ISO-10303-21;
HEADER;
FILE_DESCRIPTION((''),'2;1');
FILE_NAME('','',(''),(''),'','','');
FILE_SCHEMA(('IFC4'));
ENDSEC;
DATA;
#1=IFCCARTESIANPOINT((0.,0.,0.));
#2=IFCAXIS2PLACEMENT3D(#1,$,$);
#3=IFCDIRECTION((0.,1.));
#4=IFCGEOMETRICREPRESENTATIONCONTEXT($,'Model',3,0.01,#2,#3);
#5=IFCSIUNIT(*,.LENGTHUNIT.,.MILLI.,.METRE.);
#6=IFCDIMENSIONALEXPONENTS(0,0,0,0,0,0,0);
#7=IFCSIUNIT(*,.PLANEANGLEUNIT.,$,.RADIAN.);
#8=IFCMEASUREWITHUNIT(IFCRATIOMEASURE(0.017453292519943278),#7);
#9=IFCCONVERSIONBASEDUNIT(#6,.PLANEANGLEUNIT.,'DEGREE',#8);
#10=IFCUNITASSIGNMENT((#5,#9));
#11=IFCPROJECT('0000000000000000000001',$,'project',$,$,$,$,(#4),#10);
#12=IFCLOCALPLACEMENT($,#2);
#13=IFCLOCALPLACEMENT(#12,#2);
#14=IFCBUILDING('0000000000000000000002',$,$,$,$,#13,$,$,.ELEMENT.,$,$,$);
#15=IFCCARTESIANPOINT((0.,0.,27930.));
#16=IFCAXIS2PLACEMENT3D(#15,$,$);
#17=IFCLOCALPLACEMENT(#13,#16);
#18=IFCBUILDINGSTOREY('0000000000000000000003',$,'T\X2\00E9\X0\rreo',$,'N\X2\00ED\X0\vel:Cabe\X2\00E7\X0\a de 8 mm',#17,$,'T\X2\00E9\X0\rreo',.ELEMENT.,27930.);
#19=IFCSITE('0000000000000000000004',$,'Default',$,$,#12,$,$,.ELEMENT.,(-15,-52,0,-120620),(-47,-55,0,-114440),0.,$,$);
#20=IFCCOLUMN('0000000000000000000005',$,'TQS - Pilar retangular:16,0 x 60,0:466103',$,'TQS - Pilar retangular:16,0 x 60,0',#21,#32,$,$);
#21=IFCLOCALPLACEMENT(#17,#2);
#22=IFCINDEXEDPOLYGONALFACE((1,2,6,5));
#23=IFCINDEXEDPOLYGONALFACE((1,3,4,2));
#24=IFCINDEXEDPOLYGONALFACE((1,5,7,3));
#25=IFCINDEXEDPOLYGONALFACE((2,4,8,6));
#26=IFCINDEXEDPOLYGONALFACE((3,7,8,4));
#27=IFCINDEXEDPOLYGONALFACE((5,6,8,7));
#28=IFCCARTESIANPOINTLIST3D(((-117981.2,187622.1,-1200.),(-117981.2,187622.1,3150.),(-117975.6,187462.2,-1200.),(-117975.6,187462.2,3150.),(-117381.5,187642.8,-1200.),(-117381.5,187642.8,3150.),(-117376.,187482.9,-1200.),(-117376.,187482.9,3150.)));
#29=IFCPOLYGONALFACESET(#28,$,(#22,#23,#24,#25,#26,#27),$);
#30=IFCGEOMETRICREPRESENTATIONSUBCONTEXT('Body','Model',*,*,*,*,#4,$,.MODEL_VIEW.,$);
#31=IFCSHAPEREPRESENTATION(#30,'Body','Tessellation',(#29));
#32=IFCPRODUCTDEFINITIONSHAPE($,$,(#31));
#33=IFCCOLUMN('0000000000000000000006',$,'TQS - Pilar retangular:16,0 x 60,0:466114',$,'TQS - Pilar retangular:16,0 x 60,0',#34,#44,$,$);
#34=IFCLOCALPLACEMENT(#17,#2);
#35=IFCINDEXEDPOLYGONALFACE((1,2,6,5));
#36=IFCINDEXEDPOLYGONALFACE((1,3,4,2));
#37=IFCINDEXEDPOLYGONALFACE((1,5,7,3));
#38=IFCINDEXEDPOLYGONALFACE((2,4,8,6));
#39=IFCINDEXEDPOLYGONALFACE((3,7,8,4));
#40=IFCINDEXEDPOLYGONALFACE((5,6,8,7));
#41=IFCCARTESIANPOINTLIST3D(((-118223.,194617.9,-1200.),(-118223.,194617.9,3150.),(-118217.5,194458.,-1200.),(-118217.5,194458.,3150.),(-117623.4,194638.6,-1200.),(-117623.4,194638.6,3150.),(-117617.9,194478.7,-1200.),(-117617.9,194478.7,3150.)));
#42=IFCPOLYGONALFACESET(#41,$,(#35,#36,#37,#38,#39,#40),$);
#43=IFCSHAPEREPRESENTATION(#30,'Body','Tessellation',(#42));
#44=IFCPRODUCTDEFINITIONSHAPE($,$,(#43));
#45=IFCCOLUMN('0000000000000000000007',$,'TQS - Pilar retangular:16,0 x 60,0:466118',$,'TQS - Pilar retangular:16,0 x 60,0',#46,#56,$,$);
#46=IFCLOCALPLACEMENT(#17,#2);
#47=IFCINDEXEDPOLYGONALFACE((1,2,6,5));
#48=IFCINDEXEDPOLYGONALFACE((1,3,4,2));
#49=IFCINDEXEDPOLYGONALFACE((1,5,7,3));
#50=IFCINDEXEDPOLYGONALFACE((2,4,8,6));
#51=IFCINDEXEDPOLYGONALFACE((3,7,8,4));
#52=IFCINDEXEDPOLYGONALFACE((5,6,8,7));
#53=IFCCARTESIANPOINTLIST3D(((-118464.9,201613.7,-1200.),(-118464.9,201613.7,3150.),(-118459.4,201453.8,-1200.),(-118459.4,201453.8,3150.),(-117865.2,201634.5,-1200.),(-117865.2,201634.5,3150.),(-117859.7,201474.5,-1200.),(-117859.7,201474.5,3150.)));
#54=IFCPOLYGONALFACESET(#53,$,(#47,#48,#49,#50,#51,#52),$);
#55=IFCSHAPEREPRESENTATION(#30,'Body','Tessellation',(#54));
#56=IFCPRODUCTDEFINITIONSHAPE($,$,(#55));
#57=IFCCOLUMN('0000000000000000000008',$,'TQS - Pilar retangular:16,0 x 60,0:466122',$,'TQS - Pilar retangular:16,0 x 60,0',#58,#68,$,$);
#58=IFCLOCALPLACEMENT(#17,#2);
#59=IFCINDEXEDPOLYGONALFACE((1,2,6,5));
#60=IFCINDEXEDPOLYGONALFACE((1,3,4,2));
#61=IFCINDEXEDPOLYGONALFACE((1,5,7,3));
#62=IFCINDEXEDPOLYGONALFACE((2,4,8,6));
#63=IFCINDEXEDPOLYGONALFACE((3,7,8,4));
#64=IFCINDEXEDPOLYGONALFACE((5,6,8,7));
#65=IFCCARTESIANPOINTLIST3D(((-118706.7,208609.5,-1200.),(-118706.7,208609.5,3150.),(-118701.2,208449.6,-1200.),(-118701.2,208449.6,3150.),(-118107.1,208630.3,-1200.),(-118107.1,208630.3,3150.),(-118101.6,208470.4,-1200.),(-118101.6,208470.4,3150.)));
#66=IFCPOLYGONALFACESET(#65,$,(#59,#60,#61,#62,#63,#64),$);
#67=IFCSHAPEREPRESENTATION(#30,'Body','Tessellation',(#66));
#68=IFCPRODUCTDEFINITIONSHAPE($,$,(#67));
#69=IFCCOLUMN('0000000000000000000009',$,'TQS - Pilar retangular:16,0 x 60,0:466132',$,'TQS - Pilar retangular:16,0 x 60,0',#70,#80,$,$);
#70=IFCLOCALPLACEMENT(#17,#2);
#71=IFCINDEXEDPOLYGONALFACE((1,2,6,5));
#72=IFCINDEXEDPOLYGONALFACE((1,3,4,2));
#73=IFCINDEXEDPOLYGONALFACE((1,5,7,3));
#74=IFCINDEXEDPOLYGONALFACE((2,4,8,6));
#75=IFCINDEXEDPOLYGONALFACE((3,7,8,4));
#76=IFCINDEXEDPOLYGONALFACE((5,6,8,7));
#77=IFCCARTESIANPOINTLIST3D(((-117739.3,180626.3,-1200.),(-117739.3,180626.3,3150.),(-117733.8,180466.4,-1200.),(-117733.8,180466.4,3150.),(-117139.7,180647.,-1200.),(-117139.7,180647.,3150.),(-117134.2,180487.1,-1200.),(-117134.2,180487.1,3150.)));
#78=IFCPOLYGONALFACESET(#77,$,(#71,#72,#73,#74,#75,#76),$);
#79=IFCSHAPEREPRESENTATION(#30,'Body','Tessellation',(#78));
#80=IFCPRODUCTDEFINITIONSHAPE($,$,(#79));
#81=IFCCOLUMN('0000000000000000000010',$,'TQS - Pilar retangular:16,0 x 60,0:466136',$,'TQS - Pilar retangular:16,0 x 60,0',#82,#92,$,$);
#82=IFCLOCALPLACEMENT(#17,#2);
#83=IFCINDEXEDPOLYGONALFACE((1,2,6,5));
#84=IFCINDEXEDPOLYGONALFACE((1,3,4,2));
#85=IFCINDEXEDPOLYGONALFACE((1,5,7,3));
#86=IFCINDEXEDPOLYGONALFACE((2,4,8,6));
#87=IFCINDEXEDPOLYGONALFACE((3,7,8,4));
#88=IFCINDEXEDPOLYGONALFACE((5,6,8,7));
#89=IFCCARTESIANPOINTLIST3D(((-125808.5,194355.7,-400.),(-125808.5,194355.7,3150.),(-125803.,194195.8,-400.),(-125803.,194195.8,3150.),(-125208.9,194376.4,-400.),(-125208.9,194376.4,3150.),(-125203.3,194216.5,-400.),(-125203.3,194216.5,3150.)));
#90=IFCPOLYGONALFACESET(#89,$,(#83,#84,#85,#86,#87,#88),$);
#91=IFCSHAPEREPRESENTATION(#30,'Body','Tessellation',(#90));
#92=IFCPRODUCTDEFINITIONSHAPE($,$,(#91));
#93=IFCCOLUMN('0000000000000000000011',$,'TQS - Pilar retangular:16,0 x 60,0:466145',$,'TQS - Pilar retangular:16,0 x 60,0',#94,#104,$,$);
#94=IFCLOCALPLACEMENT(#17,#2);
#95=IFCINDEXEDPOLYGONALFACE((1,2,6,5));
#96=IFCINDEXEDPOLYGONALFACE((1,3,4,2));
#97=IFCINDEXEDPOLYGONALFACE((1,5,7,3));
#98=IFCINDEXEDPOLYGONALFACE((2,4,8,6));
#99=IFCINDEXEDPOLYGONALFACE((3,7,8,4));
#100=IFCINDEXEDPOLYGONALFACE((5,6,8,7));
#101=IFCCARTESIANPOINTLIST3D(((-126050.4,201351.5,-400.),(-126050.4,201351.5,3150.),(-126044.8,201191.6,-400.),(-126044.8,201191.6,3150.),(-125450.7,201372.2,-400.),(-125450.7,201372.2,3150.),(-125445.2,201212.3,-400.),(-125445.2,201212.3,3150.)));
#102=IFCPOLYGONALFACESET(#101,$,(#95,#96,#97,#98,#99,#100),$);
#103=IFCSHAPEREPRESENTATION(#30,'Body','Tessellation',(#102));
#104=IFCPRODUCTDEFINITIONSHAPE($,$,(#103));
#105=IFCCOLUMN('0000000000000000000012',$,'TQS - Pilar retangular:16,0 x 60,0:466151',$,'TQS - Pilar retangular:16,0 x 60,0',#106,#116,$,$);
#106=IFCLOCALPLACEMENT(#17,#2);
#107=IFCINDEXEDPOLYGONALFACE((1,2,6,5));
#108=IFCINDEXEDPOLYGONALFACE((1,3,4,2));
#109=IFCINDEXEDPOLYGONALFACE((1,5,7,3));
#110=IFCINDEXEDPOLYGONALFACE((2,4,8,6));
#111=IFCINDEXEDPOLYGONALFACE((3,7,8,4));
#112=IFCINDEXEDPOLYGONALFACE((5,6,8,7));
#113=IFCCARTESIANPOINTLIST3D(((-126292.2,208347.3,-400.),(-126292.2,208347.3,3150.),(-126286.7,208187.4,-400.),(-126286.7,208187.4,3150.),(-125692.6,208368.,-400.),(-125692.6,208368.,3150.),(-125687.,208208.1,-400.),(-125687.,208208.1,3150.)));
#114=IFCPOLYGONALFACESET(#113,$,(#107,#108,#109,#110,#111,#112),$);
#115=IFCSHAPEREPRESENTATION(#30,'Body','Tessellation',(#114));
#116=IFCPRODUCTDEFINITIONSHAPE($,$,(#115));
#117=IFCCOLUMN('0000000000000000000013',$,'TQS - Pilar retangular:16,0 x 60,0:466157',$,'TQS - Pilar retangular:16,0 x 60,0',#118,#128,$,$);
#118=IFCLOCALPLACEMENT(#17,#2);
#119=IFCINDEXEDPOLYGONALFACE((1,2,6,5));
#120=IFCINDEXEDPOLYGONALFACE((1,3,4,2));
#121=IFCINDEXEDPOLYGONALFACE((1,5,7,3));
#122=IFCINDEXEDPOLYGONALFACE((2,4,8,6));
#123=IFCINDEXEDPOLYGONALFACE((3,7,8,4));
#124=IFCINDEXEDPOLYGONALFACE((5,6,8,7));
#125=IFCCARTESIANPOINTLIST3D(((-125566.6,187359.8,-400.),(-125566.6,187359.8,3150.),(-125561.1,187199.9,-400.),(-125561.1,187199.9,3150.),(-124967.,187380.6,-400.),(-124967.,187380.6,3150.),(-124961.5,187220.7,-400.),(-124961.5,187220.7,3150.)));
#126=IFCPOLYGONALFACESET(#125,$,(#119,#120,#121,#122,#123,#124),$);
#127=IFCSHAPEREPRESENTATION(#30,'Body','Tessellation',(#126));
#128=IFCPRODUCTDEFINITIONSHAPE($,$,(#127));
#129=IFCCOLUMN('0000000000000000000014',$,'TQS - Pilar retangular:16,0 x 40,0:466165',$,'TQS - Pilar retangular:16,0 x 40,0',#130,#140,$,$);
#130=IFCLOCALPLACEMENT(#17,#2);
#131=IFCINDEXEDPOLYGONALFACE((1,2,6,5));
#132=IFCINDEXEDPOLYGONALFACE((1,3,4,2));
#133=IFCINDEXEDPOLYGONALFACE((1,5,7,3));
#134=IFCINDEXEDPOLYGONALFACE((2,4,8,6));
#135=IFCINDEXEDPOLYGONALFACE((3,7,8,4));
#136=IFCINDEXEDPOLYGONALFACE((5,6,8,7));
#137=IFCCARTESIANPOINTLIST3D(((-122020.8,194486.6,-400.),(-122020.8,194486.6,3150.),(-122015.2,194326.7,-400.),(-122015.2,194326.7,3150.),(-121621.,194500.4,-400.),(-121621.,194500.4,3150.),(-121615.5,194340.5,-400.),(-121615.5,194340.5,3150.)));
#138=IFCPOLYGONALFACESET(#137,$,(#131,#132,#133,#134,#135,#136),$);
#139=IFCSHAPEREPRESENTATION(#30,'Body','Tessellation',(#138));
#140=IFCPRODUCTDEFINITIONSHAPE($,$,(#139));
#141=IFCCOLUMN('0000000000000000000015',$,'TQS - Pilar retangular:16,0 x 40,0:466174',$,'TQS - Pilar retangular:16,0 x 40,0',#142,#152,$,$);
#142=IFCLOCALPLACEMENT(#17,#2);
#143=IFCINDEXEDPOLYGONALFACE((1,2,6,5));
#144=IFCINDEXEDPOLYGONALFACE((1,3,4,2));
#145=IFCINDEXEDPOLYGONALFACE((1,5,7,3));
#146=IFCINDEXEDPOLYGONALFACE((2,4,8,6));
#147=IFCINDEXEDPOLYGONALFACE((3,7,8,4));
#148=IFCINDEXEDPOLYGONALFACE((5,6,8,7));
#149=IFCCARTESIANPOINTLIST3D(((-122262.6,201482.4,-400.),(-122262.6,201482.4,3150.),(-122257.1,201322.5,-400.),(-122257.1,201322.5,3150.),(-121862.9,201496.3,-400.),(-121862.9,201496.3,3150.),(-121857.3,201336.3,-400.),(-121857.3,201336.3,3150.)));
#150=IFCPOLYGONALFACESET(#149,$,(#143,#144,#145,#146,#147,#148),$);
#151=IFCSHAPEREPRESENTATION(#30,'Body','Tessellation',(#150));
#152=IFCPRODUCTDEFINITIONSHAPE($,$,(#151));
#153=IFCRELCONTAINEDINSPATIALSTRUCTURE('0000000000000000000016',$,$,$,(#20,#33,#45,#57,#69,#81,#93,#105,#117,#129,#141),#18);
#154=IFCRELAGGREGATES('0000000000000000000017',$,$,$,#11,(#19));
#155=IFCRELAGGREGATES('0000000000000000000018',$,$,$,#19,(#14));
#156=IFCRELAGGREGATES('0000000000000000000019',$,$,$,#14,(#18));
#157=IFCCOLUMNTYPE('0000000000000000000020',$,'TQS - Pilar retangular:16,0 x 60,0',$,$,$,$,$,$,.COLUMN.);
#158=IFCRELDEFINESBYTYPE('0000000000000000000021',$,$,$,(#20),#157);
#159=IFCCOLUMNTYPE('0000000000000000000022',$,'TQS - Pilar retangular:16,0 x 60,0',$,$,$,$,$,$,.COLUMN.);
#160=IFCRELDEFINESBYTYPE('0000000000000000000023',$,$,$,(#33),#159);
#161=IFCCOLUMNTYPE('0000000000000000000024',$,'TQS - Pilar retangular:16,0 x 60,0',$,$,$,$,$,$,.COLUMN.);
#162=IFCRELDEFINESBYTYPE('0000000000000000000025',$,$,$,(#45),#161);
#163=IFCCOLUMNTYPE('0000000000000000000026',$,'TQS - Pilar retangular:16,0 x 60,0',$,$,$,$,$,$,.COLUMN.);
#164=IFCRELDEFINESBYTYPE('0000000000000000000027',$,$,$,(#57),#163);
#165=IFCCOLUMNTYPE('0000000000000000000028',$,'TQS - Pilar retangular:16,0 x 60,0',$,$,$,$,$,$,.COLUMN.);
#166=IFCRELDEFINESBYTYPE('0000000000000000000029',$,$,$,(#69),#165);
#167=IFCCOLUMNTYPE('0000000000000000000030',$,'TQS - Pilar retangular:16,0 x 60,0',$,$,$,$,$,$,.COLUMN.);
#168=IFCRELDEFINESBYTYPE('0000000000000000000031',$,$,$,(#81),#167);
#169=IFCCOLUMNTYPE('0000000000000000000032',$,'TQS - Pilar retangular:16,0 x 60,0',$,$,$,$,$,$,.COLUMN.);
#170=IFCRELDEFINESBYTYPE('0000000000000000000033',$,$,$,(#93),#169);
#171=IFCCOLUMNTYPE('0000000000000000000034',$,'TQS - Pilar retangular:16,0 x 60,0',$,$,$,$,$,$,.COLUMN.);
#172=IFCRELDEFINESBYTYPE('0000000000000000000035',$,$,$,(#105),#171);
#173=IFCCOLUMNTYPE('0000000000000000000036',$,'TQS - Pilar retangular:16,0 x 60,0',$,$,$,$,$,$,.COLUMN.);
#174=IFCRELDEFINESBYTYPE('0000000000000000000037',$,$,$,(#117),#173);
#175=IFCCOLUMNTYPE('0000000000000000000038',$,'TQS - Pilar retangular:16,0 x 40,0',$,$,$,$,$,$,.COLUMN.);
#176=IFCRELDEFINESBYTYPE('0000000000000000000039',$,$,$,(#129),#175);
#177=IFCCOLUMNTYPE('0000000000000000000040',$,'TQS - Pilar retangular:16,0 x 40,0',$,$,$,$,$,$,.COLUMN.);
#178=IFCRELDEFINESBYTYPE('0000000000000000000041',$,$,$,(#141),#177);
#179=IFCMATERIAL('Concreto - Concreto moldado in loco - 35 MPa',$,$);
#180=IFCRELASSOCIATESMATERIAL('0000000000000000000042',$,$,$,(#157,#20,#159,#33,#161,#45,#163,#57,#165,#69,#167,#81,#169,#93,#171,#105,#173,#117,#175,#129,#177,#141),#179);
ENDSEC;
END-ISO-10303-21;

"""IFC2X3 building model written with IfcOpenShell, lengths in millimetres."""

from ifc_helpers import new_model, entity, si_unit, converted_unit, direction, frame, origin, origin_2d_with_axis, place, context, subcontext, project, spatial, rectangle, extrude, source, transform, mapped, material, type_object, type_shapes, element, save


model = new_model("IFC2X3")

# Units and contexts
model_context = context("Model", 3, precision=0.01, world=origin(), true_north=direction((0.0, 1.0)))
body_context = subcontext(model_context, "Body", "Model", "MODEL_VIEW")
ifc_project = project(units=[si_unit("LENGTHUNIT", "METRE", prefix="MILLI"), converted_unit("PLANEANGLEUNIT", "DEGREE", entity("IfcRatioMeasure", 0.017453292519943278), si_unit("PLANEANGLEUNIT", "RADIAN"), dimensions=[0, 0, 0, 0, 0, 0, 0])], contexts=[model_context])

# Site, building, storey
site_placement = place(None, origin())
site = spatial("IfcSite", under=ifc_project, at=site_placement, Name="Default", CompositionType="ELEMENT", RefLatitude=(-15, -52, 0, -120620), RefLongitude=(-47, -55, 0, -114440), RefElevation=0.0)
building_placement = place(site_placement, origin())
building = spatial("IfcBuilding", under=site, at=building_placement, CompositionType="ELEMENT")
storey_placement = place(building_placement, frame((0.0, 0.0, 27930.0)))
storey = spatial("IfcBuildingStorey", under=building, at=storey_placement, Name="Térreo", ObjectType="Nível:Cabeça de 8 mm", LongName="Térreo", CompositionType="ELEMENT", Elevation=27930.0)

# Columns
ifc_material = material(Name="Concreto - Concreto moldado in loco - 35 MPa")
column_type_1 = type_object("IfcColumnType", Name="TQS - Pilar retangular:16,0 x 60,0", PredefinedType="COLUMN", material=ifc_material)
shared_shape_1 = source(origin(), body_context, "Body", "SweptSolid", [
    extrude(rectangle(XDim=600.0, YDim=160.0, at=origin_2d_with_axis()), frame((-117678.6, 187552.5, 26730.0), z_axis=(0.0, 0.0, 1.0), x_axis=(-0.999403, -0.034551, 0.0)), (0.0, 0.0, 1.0), 4350.0),
])
type_shapes(column_type_1, [shared_shape_1])
column_1_placement = place(storey_placement, frame((0.0, 0.0, -27930.0)))
element("IfcColumn", 1, at=column_1_placement, inside=storey, type_object=column_type_1, material=ifc_material, Name="TQS - Pilar retangular:16,0 x 60,0:466103", ObjectType="TQS - Pilar retangular:16,0 x 60,0", context=body_context, shape_type="MappedRepresentation", body=[
    mapped(shared_shape_1, transform((0.0, 0.0, 0.0), scale=1.0)),
])
column_type_2 = type_object("IfcColumnType", Name="TQS - Pilar retangular:16,0 x 60,0", PredefinedType="COLUMN", material=ifc_material)
shared_shape_2 = source(origin(), body_context, "Body", "SweptSolid", [
    extrude(rectangle(XDim=600.0, YDim=160.0, at=origin_2d_with_axis()), frame((-117920.4, 194548.3, 26730.0), z_axis=(0.0, 0.0, 1.0), x_axis=(-0.999403, -0.034551, 0.0)), (0.0, 0.0, 1.0), 4350.0),
])
type_shapes(column_type_2, [shared_shape_2])
column_2_placement = place(storey_placement, frame((0.0, 0.0, -27930.0)))
element("IfcColumn", 2, at=column_2_placement, inside=storey, type_object=column_type_2, material=ifc_material, Name="TQS - Pilar retangular:16,0 x 60,0:466114", ObjectType="TQS - Pilar retangular:16,0 x 60,0", context=body_context, shape_type="MappedRepresentation", body=[
    mapped(shared_shape_2, transform((0.0, 0.0, 0.0), scale=1.0)),
])
column_type_3 = type_object("IfcColumnType", Name="TQS - Pilar retangular:16,0 x 60,0", PredefinedType="COLUMN", material=ifc_material)
shared_shape_3 = source(origin(), body_context, "Body", "SweptSolid", [
    extrude(rectangle(XDim=600.0, YDim=160.0, at=origin_2d_with_axis()), frame((-118162.3, 201544.1, 26730.0), z_axis=(0.0, 0.0, 1.0), x_axis=(-0.999403, -0.034551, 0.0)), (0.0, 0.0, 1.0), 4350.0),
])
type_shapes(column_type_3, [shared_shape_3])
column_3_placement = place(storey_placement, frame((0.0, 0.0, -27930.0)))
element("IfcColumn", 3, at=column_3_placement, inside=storey, type_object=column_type_3, material=ifc_material, Name="TQS - Pilar retangular:16,0 x 60,0:466118", ObjectType="TQS - Pilar retangular:16,0 x 60,0", context=body_context, shape_type="MappedRepresentation", body=[
    mapped(shared_shape_3, transform((0.0, 0.0, 0.0), scale=1.0)),
])
column_type_4 = type_object("IfcColumnType", Name="TQS - Pilar retangular:16,0 x 60,0", PredefinedType="COLUMN", material=ifc_material)
shared_shape_4 = source(origin(), body_context, "Body", "SweptSolid", [
    extrude(rectangle(XDim=600.0, YDim=160.0, at=origin_2d_with_axis()), frame((-118404.2, 208540.0, 26730.0), z_axis=(0.0, 0.0, 1.0), x_axis=(-0.999403, -0.034551, 0.0)), (0.0, 0.0, 1.0), 4350.0),
])
type_shapes(column_type_4, [shared_shape_4])
column_4_placement = place(storey_placement, frame((0.0, 0.0, -27930.0)))
element("IfcColumn", 4, at=column_4_placement, inside=storey, type_object=column_type_4, material=ifc_material, Name="TQS - Pilar retangular:16,0 x 60,0:466122", ObjectType="TQS - Pilar retangular:16,0 x 60,0", context=body_context, shape_type="MappedRepresentation", body=[
    mapped(shared_shape_4, transform((0.0, 0.0, 0.0), scale=1.0)),
])
column_type_5 = type_object("IfcColumnType", Name="TQS - Pilar retangular:16,0 x 60,0", PredefinedType="COLUMN", material=ifc_material)
shared_shape_5 = source(origin(), body_context, "Body", "SweptSolid", [
    extrude(rectangle(XDim=600.0, YDim=160.0, at=origin_2d_with_axis()), frame((-117436.7, 180556.7, 26730.0), z_axis=(0.0, 0.0, 1.0), x_axis=(-0.999403, -0.034551, 0.0)), (0.0, 0.0, 1.0), 4350.0),
])
type_shapes(column_type_5, [shared_shape_5])
column_5_placement = place(storey_placement, frame((0.0, 0.0, -27930.0)))
element("IfcColumn", 5, at=column_5_placement, inside=storey, type_object=column_type_5, material=ifc_material, Name="TQS - Pilar retangular:16,0 x 60,0:466132", ObjectType="TQS - Pilar retangular:16,0 x 60,0", context=body_context, shape_type="MappedRepresentation", body=[
    mapped(shared_shape_5, transform((0.0, 0.0, 0.0), scale=1.0)),
])
column_type_6 = type_object("IfcColumnType", Name="TQS - Pilar retangular:16,0 x 60,0", PredefinedType="COLUMN", material=ifc_material)
shared_shape_6 = source(origin(), body_context, "Body", "SweptSolid", [
    extrude(rectangle(XDim=600.0, YDim=160.0, at=origin_2d_with_axis()), frame((-125505.9, 194286.1, 27530.0), z_axis=(0.0, 0.0, 1.0), x_axis=(-0.999403, -0.034551, 0.0)), (0.0, 0.0, 1.0), 3550.0),
])
type_shapes(column_type_6, [shared_shape_6])
column_6_placement = place(storey_placement, frame((0.0, 0.0, -27930.0)))
element("IfcColumn", 6, at=column_6_placement, inside=storey, type_object=column_type_6, material=ifc_material, Name="TQS - Pilar retangular:16,0 x 60,0:466136", ObjectType="TQS - Pilar retangular:16,0 x 60,0", context=body_context, shape_type="MappedRepresentation", body=[
    mapped(shared_shape_6, transform((0.0, 0.0, 0.0), scale=1.0)),
])
column_type_7 = type_object("IfcColumnType", Name="TQS - Pilar retangular:16,0 x 60,0", PredefinedType="COLUMN", material=ifc_material)
shared_shape_7 = source(origin(), body_context, "Body", "SweptSolid", [
    extrude(rectangle(XDim=600.0, YDim=160.0, at=origin_2d_with_axis()), frame((-125747.8, 201281.9, 27530.0), z_axis=(0.0, 0.0, 1.0), x_axis=(-0.999403, -0.034551, 0.0)), (0.0, 0.0, 1.0), 3550.0),
])
type_shapes(column_type_7, [shared_shape_7])
column_7_placement = place(storey_placement, frame((0.0, 0.0, -27930.0)))
element("IfcColumn", 7, at=column_7_placement, inside=storey, type_object=column_type_7, material=ifc_material, Name="TQS - Pilar retangular:16,0 x 60,0:466145", ObjectType="TQS - Pilar retangular:16,0 x 60,0", context=body_context, shape_type="MappedRepresentation", body=[
    mapped(shared_shape_7, transform((0.0, 0.0, 0.0), scale=1.0)),
])
column_type_8 = type_object("IfcColumnType", Name="TQS - Pilar retangular:16,0 x 60,0", PredefinedType="COLUMN", material=ifc_material)
shared_shape_8 = source(origin(), body_context, "Body", "SweptSolid", [
    extrude(rectangle(XDim=600.0, YDim=160.0, at=origin_2d_with_axis()), frame((-125989.6, 208277.7, 27530.0), z_axis=(0.0, 0.0, 1.0), x_axis=(-0.999403, -0.034551, 0.0)), (0.0, 0.0, 1.0), 3550.0),
])
type_shapes(column_type_8, [shared_shape_8])
column_8_placement = place(storey_placement, frame((0.0, 0.0, -27930.0)))
element("IfcColumn", 8, at=column_8_placement, inside=storey, type_object=column_type_8, material=ifc_material, Name="TQS - Pilar retangular:16,0 x 60,0:466151", ObjectType="TQS - Pilar retangular:16,0 x 60,0", context=body_context, shape_type="MappedRepresentation", body=[
    mapped(shared_shape_8, transform((0.0, 0.0, 0.0), scale=1.0)),
])
column_type_9 = type_object("IfcColumnType", Name="TQS - Pilar retangular:16,0 x 60,0", PredefinedType="COLUMN", material=ifc_material)
shared_shape_9 = source(origin(), body_context, "Body", "SweptSolid", [
    extrude(rectangle(XDim=600.0, YDim=160.0, at=origin_2d_with_axis()), frame((-125264.1, 187290.3, 27530.0), z_axis=(0.0, 0.0, 1.0), x_axis=(-0.999403, -0.034551, 0.0)), (0.0, 0.0, 1.0), 3550.0),
])
type_shapes(column_type_9, [shared_shape_9])
column_9_placement = place(storey_placement, frame((0.0, 0.0, -27930.0)))
element("IfcColumn", 9, at=column_9_placement, inside=storey, type_object=column_type_9, material=ifc_material, Name="TQS - Pilar retangular:16,0 x 60,0:466157", ObjectType="TQS - Pilar retangular:16,0 x 60,0", context=body_context, shape_type="MappedRepresentation", body=[
    mapped(shared_shape_9, transform((0.0, 0.0, 0.0), scale=1.0)),
])
column_type_10 = type_object("IfcColumnType", Name="TQS - Pilar retangular:16,0 x 40,0", PredefinedType="COLUMN", material=ifc_material)
shared_shape_10 = source(origin(), body_context, "Body", "SweptSolid", [
    extrude(rectangle(XDim=400.0, YDim=160.0, at=origin_2d_with_axis()), frame((-121818.1, 194413.6, 27530.0), z_axis=(0.0, 0.0, 1.0), x_axis=(-0.999403, -0.034551, 0.0)), (0.0, 0.0, 1.0), 3550.0),
])
type_shapes(column_type_10, [shared_shape_10])
column_10_placement = place(storey_placement, frame((0.0, 0.0, -27930.0)))
element("IfcColumn", 10, at=column_10_placement, inside=storey, type_object=column_type_10, material=ifc_material, Name="TQS - Pilar retangular:16,0 x 40,0:466165", ObjectType="TQS - Pilar retangular:16,0 x 40,0", context=body_context, shape_type="MappedRepresentation", body=[
    mapped(shared_shape_10, transform((0.0, 0.0, 0.0), scale=1.0)),
])
column_type_11 = type_object("IfcColumnType", Name="TQS - Pilar retangular:16,0 x 40,0", PredefinedType="COLUMN", material=ifc_material)
shared_shape_11 = source(origin(), body_context, "Body", "SweptSolid", [
    extrude(rectangle(XDim=400.0, YDim=160.0, at=origin_2d_with_axis()), frame((-122060.0, 201409.4, 27530.0), z_axis=(0.0, 0.0, 1.0), x_axis=(-0.999403, -0.034551, 0.0)), (0.0, 0.0, 1.0), 3550.0),
])
type_shapes(column_type_11, [shared_shape_11])
column_11_placement = place(storey_placement, frame((0.0, 0.0, -27930.0)))
element("IfcColumn", 11, at=column_11_placement, inside=storey, type_object=column_type_11, material=ifc_material, Name="TQS - Pilar retangular:16,0 x 40,0:466174", ObjectType="TQS - Pilar retangular:16,0 x 40,0", context=body_context, shape_type="MappedRepresentation", body=[
    mapped(shared_shape_11, transform((0.0, 0.0, 0.0), scale=1.0)),
])

save(model, "model.ifc")
